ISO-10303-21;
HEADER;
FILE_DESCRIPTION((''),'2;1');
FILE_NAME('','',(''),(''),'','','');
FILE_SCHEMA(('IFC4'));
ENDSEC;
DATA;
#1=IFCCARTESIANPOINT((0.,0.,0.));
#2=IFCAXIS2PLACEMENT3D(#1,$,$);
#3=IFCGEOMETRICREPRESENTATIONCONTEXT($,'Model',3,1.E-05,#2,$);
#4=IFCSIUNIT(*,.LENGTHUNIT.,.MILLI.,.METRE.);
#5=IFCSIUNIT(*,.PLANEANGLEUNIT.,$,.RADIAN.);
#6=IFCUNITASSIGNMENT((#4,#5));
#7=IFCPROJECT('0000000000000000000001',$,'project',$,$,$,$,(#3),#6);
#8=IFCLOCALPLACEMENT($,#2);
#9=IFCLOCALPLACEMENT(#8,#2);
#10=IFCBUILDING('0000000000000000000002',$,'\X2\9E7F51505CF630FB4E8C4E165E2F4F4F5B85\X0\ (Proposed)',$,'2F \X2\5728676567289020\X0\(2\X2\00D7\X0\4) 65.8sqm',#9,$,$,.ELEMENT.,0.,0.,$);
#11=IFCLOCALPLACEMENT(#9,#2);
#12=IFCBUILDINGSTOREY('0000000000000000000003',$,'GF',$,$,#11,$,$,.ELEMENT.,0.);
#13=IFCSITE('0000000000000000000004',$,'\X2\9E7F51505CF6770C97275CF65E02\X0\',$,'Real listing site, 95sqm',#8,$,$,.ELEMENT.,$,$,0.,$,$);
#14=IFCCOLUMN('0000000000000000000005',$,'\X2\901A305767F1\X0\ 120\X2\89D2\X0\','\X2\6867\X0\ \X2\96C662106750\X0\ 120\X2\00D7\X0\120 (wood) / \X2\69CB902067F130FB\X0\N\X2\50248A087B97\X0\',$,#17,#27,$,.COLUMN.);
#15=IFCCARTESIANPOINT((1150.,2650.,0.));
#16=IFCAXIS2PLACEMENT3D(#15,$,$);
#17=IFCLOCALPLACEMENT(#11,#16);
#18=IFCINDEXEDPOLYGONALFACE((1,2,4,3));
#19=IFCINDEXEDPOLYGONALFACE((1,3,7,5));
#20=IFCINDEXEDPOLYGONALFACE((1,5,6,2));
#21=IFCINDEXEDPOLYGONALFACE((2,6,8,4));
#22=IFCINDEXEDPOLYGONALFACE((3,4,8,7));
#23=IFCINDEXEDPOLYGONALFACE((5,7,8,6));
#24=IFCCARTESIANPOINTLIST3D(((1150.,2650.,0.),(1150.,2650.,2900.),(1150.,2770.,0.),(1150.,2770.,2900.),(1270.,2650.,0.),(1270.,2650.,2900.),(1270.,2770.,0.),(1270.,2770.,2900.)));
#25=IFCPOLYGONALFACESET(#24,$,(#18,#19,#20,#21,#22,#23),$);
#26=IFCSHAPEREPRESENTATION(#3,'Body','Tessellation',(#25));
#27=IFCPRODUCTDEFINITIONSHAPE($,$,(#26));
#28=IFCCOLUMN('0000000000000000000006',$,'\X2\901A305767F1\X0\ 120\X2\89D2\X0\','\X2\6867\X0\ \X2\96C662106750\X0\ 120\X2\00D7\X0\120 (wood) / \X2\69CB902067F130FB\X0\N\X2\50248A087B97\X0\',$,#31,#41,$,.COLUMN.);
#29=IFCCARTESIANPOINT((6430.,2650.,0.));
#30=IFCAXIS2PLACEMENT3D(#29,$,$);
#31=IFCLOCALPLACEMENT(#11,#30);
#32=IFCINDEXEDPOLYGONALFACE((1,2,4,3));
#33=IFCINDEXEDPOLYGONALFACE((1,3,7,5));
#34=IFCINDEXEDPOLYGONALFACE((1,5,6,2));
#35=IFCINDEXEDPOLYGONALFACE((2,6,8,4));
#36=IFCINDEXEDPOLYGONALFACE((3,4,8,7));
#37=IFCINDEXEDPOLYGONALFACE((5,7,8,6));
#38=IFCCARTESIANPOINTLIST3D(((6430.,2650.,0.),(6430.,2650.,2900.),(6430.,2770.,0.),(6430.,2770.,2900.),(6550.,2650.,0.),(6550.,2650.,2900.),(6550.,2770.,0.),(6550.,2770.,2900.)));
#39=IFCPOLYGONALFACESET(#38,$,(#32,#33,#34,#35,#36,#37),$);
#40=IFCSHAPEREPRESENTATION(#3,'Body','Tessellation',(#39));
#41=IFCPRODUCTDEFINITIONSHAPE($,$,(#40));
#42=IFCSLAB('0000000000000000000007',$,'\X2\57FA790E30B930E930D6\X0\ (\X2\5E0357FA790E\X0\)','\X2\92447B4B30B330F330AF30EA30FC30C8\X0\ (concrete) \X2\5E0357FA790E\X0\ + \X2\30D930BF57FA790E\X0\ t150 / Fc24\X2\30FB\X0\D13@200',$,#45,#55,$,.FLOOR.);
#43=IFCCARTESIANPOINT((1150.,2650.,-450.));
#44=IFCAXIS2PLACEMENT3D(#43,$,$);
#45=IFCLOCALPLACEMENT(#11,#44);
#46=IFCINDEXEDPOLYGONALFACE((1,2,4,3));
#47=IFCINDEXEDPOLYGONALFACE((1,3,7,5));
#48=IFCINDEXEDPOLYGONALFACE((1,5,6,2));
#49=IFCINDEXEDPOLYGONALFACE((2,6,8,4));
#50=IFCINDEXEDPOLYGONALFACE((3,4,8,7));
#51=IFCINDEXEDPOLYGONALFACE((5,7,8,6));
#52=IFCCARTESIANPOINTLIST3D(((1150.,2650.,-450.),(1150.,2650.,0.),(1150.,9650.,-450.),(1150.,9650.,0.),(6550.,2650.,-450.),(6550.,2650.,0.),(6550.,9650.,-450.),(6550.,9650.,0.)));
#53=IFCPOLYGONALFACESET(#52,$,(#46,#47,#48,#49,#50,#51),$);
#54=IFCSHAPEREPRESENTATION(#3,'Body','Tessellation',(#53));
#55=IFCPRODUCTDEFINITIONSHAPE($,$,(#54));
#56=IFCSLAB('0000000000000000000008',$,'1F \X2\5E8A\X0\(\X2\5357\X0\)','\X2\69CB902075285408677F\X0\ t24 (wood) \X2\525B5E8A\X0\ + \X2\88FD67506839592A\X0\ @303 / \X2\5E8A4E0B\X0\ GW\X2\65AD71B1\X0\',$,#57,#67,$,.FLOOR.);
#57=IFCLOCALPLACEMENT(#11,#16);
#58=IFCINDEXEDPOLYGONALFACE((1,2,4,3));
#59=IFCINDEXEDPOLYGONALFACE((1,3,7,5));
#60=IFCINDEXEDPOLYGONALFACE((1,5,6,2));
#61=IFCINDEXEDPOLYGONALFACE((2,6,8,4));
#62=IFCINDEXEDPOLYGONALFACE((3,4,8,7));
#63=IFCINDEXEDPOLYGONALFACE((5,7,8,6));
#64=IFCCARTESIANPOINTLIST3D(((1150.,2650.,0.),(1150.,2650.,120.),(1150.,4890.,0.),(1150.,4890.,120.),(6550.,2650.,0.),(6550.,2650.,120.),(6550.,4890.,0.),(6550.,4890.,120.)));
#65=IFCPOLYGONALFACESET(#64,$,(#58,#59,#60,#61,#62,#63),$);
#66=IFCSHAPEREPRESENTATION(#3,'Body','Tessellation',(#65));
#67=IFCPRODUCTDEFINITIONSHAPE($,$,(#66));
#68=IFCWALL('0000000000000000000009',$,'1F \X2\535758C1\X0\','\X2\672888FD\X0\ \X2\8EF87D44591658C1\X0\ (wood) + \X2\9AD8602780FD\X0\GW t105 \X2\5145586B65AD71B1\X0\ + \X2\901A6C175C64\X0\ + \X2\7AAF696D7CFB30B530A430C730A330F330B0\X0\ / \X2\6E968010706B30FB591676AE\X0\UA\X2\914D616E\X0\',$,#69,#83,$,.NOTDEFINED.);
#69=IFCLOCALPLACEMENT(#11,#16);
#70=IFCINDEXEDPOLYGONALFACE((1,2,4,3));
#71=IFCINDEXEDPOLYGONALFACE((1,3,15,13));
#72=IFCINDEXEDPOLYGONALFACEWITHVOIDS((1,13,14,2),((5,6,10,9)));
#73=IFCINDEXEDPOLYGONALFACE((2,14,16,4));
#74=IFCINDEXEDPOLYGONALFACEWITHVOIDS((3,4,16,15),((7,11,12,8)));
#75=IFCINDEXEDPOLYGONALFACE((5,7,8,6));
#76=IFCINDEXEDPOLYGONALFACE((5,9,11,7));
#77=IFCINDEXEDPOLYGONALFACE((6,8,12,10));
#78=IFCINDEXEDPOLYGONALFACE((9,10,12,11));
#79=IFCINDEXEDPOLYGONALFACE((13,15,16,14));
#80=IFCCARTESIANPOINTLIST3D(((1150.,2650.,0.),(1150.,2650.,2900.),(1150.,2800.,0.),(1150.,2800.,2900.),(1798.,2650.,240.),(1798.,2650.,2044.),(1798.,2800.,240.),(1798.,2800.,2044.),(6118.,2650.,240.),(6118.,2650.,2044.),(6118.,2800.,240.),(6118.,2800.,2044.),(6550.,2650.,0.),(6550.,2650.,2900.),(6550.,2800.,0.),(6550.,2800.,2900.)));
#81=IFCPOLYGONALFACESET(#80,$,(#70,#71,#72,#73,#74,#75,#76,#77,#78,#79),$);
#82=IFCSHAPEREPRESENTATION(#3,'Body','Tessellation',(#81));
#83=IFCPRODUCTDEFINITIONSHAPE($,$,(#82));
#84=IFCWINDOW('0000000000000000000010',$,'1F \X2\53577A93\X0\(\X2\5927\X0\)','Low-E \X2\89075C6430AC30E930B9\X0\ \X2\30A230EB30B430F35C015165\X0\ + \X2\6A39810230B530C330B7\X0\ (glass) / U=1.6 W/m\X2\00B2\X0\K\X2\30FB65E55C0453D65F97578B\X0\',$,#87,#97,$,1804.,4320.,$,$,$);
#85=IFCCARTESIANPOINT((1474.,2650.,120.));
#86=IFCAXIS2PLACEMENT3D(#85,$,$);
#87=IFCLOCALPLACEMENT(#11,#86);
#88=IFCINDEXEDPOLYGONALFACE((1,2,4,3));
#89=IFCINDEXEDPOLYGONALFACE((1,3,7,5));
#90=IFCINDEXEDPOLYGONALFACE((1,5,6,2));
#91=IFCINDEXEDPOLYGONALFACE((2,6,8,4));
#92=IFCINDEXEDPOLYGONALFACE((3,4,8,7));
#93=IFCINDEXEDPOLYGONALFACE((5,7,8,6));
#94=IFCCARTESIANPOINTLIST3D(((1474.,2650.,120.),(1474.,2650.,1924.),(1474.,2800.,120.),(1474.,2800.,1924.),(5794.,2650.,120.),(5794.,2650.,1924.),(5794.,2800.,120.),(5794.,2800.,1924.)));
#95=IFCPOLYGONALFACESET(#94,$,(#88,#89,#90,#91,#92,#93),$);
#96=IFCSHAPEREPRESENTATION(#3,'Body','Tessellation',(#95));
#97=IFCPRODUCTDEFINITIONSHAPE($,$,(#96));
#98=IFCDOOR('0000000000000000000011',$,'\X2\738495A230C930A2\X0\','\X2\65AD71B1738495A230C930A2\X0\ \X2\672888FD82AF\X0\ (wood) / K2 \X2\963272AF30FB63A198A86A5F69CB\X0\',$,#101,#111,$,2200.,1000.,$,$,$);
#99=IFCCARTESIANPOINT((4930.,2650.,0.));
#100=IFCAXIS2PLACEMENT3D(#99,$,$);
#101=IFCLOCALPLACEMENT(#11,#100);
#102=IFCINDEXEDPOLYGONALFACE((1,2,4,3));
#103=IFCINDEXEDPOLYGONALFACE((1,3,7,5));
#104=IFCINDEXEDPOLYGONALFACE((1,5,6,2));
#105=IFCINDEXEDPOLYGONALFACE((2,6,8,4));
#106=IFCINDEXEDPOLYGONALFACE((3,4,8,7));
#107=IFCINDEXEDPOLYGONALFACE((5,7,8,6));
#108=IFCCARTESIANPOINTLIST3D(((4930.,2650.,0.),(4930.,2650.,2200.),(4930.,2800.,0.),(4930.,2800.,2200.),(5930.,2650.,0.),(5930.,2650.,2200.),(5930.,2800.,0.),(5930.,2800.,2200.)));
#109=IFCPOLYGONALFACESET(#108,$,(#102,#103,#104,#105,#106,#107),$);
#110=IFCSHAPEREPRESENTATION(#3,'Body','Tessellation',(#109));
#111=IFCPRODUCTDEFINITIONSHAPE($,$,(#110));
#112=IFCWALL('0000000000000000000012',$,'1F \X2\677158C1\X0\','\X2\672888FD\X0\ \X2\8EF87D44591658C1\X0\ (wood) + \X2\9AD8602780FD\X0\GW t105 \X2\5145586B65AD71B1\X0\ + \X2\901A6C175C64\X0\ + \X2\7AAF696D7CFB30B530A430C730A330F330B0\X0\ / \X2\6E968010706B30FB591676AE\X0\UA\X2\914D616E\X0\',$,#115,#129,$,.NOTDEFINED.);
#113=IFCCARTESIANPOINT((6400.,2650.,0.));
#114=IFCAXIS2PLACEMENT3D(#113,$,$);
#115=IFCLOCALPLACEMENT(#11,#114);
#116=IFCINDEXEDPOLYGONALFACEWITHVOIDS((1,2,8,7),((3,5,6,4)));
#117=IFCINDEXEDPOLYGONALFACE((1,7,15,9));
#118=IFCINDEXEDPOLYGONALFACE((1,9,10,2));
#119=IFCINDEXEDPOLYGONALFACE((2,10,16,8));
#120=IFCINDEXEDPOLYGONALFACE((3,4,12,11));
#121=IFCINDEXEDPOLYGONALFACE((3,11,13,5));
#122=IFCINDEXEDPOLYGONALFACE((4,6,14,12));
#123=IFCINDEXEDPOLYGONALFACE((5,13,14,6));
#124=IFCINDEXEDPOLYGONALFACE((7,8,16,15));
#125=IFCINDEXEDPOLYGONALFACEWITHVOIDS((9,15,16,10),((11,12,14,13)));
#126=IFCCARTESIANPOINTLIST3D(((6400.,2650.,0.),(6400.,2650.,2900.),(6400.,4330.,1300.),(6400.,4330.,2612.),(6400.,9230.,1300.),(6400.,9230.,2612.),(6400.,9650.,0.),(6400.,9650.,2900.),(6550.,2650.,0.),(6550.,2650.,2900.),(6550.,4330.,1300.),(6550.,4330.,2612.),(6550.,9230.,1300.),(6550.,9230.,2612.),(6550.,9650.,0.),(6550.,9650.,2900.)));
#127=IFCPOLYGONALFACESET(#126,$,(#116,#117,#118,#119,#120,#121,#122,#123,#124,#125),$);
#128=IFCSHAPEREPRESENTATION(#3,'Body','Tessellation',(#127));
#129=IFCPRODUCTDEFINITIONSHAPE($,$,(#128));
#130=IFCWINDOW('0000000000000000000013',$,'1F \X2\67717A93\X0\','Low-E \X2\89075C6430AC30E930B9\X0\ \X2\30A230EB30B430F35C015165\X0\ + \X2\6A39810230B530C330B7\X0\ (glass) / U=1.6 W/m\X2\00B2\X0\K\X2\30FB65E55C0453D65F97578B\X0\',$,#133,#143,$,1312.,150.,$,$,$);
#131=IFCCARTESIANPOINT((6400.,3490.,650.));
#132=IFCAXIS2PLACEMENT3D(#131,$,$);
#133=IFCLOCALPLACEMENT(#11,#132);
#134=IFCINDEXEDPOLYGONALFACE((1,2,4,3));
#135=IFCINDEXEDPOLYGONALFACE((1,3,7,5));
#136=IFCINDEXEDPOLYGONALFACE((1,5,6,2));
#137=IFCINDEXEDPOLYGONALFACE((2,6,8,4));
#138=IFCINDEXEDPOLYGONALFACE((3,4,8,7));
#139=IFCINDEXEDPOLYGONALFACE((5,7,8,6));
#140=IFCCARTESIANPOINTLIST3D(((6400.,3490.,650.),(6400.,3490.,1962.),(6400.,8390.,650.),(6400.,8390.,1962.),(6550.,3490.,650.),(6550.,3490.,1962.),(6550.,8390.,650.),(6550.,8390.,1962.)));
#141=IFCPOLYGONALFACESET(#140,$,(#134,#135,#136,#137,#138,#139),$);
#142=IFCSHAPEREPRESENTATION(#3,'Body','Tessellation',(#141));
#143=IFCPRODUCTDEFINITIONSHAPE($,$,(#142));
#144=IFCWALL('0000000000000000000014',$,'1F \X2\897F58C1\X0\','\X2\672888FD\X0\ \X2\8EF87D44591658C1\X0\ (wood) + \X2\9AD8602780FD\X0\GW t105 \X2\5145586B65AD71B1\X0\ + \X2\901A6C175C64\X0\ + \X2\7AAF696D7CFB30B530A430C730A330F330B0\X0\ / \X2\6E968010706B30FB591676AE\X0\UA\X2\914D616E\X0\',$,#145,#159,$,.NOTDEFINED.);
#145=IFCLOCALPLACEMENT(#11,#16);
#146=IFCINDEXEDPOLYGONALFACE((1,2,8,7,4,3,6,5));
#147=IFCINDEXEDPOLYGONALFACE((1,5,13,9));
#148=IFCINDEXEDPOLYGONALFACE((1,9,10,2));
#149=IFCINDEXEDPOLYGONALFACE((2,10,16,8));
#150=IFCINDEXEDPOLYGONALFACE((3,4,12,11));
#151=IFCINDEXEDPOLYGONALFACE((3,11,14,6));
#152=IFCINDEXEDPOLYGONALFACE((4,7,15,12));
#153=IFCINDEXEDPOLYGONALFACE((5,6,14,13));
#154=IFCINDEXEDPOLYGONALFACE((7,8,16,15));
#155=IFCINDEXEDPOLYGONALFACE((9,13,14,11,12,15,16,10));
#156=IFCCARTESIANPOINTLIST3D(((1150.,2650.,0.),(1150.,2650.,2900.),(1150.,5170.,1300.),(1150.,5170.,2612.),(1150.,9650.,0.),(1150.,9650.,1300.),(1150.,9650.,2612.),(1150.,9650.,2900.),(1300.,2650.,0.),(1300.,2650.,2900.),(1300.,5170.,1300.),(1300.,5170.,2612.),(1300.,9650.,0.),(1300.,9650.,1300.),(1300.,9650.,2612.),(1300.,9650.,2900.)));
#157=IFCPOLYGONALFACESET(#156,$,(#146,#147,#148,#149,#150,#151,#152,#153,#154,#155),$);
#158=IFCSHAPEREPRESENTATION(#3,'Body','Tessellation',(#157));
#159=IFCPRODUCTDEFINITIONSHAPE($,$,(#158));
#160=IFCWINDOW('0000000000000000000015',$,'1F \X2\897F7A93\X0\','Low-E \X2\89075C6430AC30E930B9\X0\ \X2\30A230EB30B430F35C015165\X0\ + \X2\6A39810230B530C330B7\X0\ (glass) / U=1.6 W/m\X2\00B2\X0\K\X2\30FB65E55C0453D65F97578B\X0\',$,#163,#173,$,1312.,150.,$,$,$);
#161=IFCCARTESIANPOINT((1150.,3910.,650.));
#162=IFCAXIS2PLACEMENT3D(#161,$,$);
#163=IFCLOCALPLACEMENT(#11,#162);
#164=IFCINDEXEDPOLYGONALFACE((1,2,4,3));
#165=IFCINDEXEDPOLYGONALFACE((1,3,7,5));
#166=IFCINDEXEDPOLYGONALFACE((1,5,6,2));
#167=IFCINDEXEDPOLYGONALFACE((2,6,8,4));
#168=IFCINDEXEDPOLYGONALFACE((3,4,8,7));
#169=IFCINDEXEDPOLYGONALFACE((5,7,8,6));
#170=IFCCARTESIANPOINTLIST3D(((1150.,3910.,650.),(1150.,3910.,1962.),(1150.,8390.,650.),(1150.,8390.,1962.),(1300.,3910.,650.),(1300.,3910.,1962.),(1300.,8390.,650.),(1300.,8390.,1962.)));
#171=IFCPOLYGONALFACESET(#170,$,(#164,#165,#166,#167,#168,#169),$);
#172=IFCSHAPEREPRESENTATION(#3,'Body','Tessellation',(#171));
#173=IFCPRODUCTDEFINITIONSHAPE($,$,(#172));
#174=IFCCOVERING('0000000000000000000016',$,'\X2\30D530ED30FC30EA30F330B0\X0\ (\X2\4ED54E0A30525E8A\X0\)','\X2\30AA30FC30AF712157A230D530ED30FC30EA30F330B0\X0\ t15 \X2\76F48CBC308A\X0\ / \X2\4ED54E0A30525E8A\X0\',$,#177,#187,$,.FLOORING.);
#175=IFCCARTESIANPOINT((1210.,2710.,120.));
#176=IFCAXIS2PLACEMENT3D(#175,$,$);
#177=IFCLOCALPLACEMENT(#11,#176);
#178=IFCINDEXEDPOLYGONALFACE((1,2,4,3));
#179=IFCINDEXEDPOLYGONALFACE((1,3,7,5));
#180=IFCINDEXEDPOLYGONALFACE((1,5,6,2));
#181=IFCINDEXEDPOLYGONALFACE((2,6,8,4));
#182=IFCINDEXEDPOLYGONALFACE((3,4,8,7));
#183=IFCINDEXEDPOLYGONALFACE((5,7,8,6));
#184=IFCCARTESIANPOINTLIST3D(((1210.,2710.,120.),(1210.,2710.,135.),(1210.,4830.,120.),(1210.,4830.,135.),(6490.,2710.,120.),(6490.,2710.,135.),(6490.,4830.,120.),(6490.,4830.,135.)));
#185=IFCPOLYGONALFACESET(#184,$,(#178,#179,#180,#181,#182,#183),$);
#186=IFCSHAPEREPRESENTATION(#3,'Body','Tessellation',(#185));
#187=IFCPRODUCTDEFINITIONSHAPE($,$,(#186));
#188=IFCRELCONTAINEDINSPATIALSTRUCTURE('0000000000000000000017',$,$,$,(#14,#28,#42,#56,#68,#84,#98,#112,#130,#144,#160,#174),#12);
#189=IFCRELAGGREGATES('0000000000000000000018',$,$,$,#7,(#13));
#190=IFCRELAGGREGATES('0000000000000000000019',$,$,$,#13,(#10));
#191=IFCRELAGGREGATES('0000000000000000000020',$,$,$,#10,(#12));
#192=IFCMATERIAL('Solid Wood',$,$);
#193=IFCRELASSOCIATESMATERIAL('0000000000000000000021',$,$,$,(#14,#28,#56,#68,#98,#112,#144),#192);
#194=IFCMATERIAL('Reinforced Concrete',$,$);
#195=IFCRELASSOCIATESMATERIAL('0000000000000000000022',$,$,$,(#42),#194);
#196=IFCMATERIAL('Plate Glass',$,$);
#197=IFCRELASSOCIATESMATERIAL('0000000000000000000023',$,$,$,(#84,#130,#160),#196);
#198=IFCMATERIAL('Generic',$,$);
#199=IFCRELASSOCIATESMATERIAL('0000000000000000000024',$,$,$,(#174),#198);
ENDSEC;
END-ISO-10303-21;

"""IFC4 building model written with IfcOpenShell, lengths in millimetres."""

from ifc_helpers import new_model, si_unit, frame, frame_2d, origin, place, context, project, spatial, rectangle, extrude, material, element, fill, save


model = new_model("IFC4")

# Units and contexts
model_context = context("Model", 3, precision=1e-05, world=origin())
ifc_project = project(units=[si_unit("LENGTHUNIT", "METRE", prefix="MILLI"), si_unit("PLANEANGLEUNIT", "RADIAN")], contexts=[model_context])

# Site, building, storey
site_placement = place(None, origin())
site = spatial("IfcSite", under=ifc_project, at=site_placement, Name="鹿児島県霧島市", ObjectType="Real listing site, 95sqm", CompositionType="ELEMENT", RefElevation=0.0)
building_placement = place(site_placement, origin())
building = spatial("IfcBuilding", under=site, at=building_placement, Name="鹿児島・二世帯住宅 (Proposed)", ObjectType="2F 在来木造(2×4) 65.8sqm", CompositionType="ELEMENT", ElevationOfRefHeight=0.0, ElevationOfTerrain=0.0)
storey_placement = place(building_placement, origin())
storey = spatial("IfcBuildingStorey", under=building, at=storey_placement, Name="GF", CompositionType="ELEMENT", Elevation=0.0)

# Columns
ifc_material_1 = material(Name="Solid Wood")
column_1_placement = place(storey_placement, frame((1150.0, 2650.0, 0.0)))
element("IfcColumn", 1, at=column_1_placement, inside=storey, material=ifc_material_1, Name="通し柱 120角", Description="桧 集成材 120×120 (wood) / 構造柱・N値計算", PredefinedType="COLUMN", context=model_context, shape_type="SweptSolid", body=[
    extrude(rectangle(XDim=120.0, YDim=120.0, at=frame_2d((60.0, 60.0))), frame((1150.0, 2650.0, 0.0)), (0.0, 0.0, 1.0), 2900.0),
])
column_2_placement = place(storey_placement, frame((6430.0, 2650.0, 0.0)))
element("IfcColumn", 2, at=column_2_placement, inside=storey, material=ifc_material_1, Name="通し柱 120角", Description="桧 集成材 120×120 (wood) / 構造柱・N値計算", PredefinedType="COLUMN", context=model_context, shape_type="SweptSolid", body=[
    extrude(rectangle(XDim=120.0, YDim=120.0, at=frame_2d((60.0, 60.0))), frame((6430.0, 2650.0, 0.0)), (0.0, 0.0, 1.0), 2900.0),
])

# Slabs
ifc_material_2 = material(Name="Reinforced Concrete")
slab_1_placement = place(storey_placement, frame((1150.0, 2650.0, -450.0)))
element("IfcSlab", 3, at=slab_1_placement, inside=storey, material=ifc_material_2, Name="基礎スラブ (布基礎)", Description="鉄筋コンクリート (concrete) 布基礎 + ベタ基礎 t150 / Fc24・D13@200", PredefinedType="FLOOR", context=model_context, shape_type="SweptSolid", body=[
    extrude(rectangle(XDim=5400.0, YDim=7000.0, at=frame_2d((2700.0, 3500.0))), frame((1150.0, 2650.0, -450.0)), (0.0, 0.0, 1.0), 450.0),
])
slab_2_placement = place(storey_placement, frame((1150.0, 2650.0, 0.0)))
element("IfcSlab", 4, at=slab_2_placement, inside=storey, material=ifc_material_1, Name="1F 床(南)", Description="構造用合板 t24 (wood) 剛床 + 製材根太 @303 / 床下 GW断熱", PredefinedType="FLOOR", context=model_context, shape_type="SweptSolid", body=[
    extrude(rectangle(XDim=5400.0, YDim=2240.0, at=frame_2d((2700.0, 1120.0))), frame((1150.0, 2650.0, 0.0)), (0.0, 0.0, 1.0), 120.0),
])

# Wall, openings, window, door
wall_1_placement = place(storey_placement, frame((1150.0, 2650.0, 0.0)))
wall_1 = element("IfcWall", 5, at=wall_1_placement, inside=storey, material=ifc_material_1, Name="1F 南壁", Description="木製 軸組外壁 (wood) + 高性能GW t105 充填断熱 + 通気層 + 窯業系サイディング / 準耐火・外皮UA配慮", PredefinedType="NOTDEFINED", context=model_context, shape_type="SweptSolid", body=[
    extrude(rectangle(XDim=5400.0, YDim=150.0, at=frame_2d((2700.0, 75.0))), frame((1150.0, 2650.0, 0.0)), (0.0, 0.0, 1.0), 2900.0),
])
opening_1_placement = place(storey_placement, frame((1474.0, 2650.0, 120.0)))
opening_1 = element("IfcOpeningElement", 6, at=opening_1_placement, cuts=wall_1, PredefinedType="NOTDEFINED", context=model_context, shape_type="SweptSolid", body=[
    extrude(rectangle(XDim=4320.0, YDim=150.0, at=frame_2d((2160.0, 75.0))), frame((1474.0, 2650.0, 120.0)), (0.0, 0.0, 1.0), 1804.0),
])
opening_2_placement = place(storey_placement, frame((4930.0, 2650.0, 0.0)))
opening_2 = element("IfcOpeningElement", 7, at=opening_2_placement, cuts=wall_1, PredefinedType="NOTDEFINED", context=model_context, shape_type="SweptSolid", body=[
    extrude(rectangle(XDim=1000.0, YDim=150.0, at=frame_2d((500.0, 75.0))), frame((4930.0, 2650.0, 0.0)), (0.0, 0.0, 1.0), 2200.0),
])
ifc_material_3 = material(Name="Plate Glass")
window_1_placement = place(storey_placement, frame((1474.0, 2650.0, 120.0)))
window_1 = element("IfcWindow", 8, at=window_1_placement, inside=storey, material=ifc_material_3, Name="1F 南窓(大)", Description="Low-E 複層ガラス アルゴン封入 + 樹脂サッシ (glass) / U=1.6 W/m²K・日射取得型", OverallHeight=1804.0, OverallWidth=4320.0, context=model_context, shape_type="SweptSolid", body=[
    extrude(rectangle(XDim=4320.0, YDim=150.0, at=frame_2d((2160.0, 75.0))), frame((1474.0, 2650.0, 120.0)), (0.0, 0.0, 1.0), 1804.0),
])
fill(opening_1, window_1)
door_placement = place(storey_placement, frame((4930.0, 2650.0, 0.0)))
door = element("IfcDoor", 9, at=door_placement, inside=storey, material=ifc_material_1, Name="玄関ドア", Description="断熱玄関ドア 木製芯 (wood) / K2 防犯・採風機構", OverallHeight=2200.0, OverallWidth=1000.0, context=model_context, shape_type="SweptSolid", body=[
    extrude(rectangle(XDim=1000.0, YDim=150.0, at=frame_2d((500.0, 75.0))), frame((4930.0, 2650.0, 0.0)), (0.0, 0.0, 1.0), 2200.0),
])
fill(opening_2, door)

# Walls, openings, windows
wall_2_placement = place(storey_placement, frame((6400.0, 2650.0, 0.0)))
wall_2 = element("IfcWall", 10, at=wall_2_placement, inside=storey, material=ifc_material_1, Name="1F 東壁", Description="木製 軸組外壁 (wood) + 高性能GW t105 充填断熱 + 通気層 + 窯業系サイディング / 準耐火・外皮UA配慮", PredefinedType="NOTDEFINED", context=model_context, shape_type="SweptSolid", body=[
    extrude(rectangle(XDim=150.0, YDim=7000.0, at=frame_2d((75.0, 3500.0))), frame((6400.0, 2650.0, 0.0)), (0.0, 0.0, 1.0), 2900.0),
])
opening_3_placement = place(storey_placement, frame((6400.0, 3490.0, 650.0)))
opening_3 = element("IfcOpeningElement", 11, at=opening_3_placement, cuts=wall_2, PredefinedType="NOTDEFINED", context=model_context, shape_type="SweptSolid", body=[
    extrude(rectangle(XDim=150.0, YDim=4900.0, at=frame_2d((75.0, 2450.0))), frame((6400.0, 3490.0, 650.0)), (0.0, 0.0, 1.0), 1312.0),
])
window_2_placement = place(storey_placement, frame((6400.0, 3490.0, 650.0)))
window_2 = element("IfcWindow", 12, at=window_2_placement, inside=storey, material=ifc_material_3, Name="1F 東窓", Description="Low-E 複層ガラス アルゴン封入 + 樹脂サッシ (glass) / U=1.6 W/m²K・日射取得型", OverallHeight=1312.0, OverallWidth=150.0, context=model_context, shape_type="SweptSolid", body=[
    extrude(rectangle(XDim=150.0, YDim=4900.0, at=frame_2d((75.0, 2450.0))), frame((6400.0, 3490.0, 650.0)), (0.0, 0.0, 1.0), 1312.0),
])
fill(opening_3, window_2)
wall_3_placement = place(storey_placement, frame((1150.0, 2650.0, 0.0)))
wall_3 = element("IfcWall", 13, at=wall_3_placement, inside=storey, material=ifc_material_1, Name="1F 西壁", Description="木製 軸組外壁 (wood) + 高性能GW t105 充填断熱 + 通気層 + 窯業系サイディング / 準耐火・外皮UA配慮", PredefinedType="NOTDEFINED", context=model_context, shape_type="SweptSolid", body=[
    extrude(rectangle(XDim=150.0, YDim=7000.0, at=frame_2d((75.0, 3500.0))), frame((1150.0, 2650.0, 0.0)), (0.0, 0.0, 1.0), 2900.0),
])
opening_4_placement = place(storey_placement, frame((1150.0, 3910.0, 650.0)))
opening_4 = element("IfcOpeningElement", 14, at=opening_4_placement, cuts=wall_3, PredefinedType="NOTDEFINED", context=model_context, shape_type="SweptSolid", body=[
    extrude(rectangle(XDim=150.0, YDim=4480.0, at=frame_2d((75.0, 2240.0))), frame((1150.0, 3910.0, 650.0)), (0.0, 0.0, 1.0), 1312.0),
])
window_3_placement = place(storey_placement, frame((1150.0, 3910.0, 650.0)))
window_3 = element("IfcWindow", 15, at=window_3_placement, inside=storey, material=ifc_material_3, Name="1F 西窓", Description="Low-E 複層ガラス アルゴン封入 + 樹脂サッシ (glass) / U=1.6 W/m²K・日射取得型", OverallHeight=1312.0, OverallWidth=150.0, context=model_context, shape_type="SweptSolid", body=[
    extrude(rectangle(XDim=150.0, YDim=4480.0, at=frame_2d((75.0, 2240.0))), frame((1150.0, 3910.0, 650.0)), (0.0, 0.0, 1.0), 1312.0),
])
fill(opening_4, window_3)

# Covering
ifc_material_4 = material(Name="Generic")
covering_1_placement = place(storey_placement, frame((1210.0, 2710.0, 120.0)))
element("IfcCovering", 16, at=covering_1_placement, inside=storey, material=ifc_material_4, Name="フローリング (仕上げ床)", Description="オーク無垢フローリング t15 直貼り / 仕上げ床", PredefinedType="FLOORING", context=model_context, shape_type="SweptSolid", body=[
    extrude(rectangle(XDim=5280.0, YDim=2120.0, at=frame_2d((2640.0, 1060.0))), frame((1210.0, 2710.0, 120.0)), (0.0, 0.0, 1.0), 15.0),
])

save(model, "model.ifc")
